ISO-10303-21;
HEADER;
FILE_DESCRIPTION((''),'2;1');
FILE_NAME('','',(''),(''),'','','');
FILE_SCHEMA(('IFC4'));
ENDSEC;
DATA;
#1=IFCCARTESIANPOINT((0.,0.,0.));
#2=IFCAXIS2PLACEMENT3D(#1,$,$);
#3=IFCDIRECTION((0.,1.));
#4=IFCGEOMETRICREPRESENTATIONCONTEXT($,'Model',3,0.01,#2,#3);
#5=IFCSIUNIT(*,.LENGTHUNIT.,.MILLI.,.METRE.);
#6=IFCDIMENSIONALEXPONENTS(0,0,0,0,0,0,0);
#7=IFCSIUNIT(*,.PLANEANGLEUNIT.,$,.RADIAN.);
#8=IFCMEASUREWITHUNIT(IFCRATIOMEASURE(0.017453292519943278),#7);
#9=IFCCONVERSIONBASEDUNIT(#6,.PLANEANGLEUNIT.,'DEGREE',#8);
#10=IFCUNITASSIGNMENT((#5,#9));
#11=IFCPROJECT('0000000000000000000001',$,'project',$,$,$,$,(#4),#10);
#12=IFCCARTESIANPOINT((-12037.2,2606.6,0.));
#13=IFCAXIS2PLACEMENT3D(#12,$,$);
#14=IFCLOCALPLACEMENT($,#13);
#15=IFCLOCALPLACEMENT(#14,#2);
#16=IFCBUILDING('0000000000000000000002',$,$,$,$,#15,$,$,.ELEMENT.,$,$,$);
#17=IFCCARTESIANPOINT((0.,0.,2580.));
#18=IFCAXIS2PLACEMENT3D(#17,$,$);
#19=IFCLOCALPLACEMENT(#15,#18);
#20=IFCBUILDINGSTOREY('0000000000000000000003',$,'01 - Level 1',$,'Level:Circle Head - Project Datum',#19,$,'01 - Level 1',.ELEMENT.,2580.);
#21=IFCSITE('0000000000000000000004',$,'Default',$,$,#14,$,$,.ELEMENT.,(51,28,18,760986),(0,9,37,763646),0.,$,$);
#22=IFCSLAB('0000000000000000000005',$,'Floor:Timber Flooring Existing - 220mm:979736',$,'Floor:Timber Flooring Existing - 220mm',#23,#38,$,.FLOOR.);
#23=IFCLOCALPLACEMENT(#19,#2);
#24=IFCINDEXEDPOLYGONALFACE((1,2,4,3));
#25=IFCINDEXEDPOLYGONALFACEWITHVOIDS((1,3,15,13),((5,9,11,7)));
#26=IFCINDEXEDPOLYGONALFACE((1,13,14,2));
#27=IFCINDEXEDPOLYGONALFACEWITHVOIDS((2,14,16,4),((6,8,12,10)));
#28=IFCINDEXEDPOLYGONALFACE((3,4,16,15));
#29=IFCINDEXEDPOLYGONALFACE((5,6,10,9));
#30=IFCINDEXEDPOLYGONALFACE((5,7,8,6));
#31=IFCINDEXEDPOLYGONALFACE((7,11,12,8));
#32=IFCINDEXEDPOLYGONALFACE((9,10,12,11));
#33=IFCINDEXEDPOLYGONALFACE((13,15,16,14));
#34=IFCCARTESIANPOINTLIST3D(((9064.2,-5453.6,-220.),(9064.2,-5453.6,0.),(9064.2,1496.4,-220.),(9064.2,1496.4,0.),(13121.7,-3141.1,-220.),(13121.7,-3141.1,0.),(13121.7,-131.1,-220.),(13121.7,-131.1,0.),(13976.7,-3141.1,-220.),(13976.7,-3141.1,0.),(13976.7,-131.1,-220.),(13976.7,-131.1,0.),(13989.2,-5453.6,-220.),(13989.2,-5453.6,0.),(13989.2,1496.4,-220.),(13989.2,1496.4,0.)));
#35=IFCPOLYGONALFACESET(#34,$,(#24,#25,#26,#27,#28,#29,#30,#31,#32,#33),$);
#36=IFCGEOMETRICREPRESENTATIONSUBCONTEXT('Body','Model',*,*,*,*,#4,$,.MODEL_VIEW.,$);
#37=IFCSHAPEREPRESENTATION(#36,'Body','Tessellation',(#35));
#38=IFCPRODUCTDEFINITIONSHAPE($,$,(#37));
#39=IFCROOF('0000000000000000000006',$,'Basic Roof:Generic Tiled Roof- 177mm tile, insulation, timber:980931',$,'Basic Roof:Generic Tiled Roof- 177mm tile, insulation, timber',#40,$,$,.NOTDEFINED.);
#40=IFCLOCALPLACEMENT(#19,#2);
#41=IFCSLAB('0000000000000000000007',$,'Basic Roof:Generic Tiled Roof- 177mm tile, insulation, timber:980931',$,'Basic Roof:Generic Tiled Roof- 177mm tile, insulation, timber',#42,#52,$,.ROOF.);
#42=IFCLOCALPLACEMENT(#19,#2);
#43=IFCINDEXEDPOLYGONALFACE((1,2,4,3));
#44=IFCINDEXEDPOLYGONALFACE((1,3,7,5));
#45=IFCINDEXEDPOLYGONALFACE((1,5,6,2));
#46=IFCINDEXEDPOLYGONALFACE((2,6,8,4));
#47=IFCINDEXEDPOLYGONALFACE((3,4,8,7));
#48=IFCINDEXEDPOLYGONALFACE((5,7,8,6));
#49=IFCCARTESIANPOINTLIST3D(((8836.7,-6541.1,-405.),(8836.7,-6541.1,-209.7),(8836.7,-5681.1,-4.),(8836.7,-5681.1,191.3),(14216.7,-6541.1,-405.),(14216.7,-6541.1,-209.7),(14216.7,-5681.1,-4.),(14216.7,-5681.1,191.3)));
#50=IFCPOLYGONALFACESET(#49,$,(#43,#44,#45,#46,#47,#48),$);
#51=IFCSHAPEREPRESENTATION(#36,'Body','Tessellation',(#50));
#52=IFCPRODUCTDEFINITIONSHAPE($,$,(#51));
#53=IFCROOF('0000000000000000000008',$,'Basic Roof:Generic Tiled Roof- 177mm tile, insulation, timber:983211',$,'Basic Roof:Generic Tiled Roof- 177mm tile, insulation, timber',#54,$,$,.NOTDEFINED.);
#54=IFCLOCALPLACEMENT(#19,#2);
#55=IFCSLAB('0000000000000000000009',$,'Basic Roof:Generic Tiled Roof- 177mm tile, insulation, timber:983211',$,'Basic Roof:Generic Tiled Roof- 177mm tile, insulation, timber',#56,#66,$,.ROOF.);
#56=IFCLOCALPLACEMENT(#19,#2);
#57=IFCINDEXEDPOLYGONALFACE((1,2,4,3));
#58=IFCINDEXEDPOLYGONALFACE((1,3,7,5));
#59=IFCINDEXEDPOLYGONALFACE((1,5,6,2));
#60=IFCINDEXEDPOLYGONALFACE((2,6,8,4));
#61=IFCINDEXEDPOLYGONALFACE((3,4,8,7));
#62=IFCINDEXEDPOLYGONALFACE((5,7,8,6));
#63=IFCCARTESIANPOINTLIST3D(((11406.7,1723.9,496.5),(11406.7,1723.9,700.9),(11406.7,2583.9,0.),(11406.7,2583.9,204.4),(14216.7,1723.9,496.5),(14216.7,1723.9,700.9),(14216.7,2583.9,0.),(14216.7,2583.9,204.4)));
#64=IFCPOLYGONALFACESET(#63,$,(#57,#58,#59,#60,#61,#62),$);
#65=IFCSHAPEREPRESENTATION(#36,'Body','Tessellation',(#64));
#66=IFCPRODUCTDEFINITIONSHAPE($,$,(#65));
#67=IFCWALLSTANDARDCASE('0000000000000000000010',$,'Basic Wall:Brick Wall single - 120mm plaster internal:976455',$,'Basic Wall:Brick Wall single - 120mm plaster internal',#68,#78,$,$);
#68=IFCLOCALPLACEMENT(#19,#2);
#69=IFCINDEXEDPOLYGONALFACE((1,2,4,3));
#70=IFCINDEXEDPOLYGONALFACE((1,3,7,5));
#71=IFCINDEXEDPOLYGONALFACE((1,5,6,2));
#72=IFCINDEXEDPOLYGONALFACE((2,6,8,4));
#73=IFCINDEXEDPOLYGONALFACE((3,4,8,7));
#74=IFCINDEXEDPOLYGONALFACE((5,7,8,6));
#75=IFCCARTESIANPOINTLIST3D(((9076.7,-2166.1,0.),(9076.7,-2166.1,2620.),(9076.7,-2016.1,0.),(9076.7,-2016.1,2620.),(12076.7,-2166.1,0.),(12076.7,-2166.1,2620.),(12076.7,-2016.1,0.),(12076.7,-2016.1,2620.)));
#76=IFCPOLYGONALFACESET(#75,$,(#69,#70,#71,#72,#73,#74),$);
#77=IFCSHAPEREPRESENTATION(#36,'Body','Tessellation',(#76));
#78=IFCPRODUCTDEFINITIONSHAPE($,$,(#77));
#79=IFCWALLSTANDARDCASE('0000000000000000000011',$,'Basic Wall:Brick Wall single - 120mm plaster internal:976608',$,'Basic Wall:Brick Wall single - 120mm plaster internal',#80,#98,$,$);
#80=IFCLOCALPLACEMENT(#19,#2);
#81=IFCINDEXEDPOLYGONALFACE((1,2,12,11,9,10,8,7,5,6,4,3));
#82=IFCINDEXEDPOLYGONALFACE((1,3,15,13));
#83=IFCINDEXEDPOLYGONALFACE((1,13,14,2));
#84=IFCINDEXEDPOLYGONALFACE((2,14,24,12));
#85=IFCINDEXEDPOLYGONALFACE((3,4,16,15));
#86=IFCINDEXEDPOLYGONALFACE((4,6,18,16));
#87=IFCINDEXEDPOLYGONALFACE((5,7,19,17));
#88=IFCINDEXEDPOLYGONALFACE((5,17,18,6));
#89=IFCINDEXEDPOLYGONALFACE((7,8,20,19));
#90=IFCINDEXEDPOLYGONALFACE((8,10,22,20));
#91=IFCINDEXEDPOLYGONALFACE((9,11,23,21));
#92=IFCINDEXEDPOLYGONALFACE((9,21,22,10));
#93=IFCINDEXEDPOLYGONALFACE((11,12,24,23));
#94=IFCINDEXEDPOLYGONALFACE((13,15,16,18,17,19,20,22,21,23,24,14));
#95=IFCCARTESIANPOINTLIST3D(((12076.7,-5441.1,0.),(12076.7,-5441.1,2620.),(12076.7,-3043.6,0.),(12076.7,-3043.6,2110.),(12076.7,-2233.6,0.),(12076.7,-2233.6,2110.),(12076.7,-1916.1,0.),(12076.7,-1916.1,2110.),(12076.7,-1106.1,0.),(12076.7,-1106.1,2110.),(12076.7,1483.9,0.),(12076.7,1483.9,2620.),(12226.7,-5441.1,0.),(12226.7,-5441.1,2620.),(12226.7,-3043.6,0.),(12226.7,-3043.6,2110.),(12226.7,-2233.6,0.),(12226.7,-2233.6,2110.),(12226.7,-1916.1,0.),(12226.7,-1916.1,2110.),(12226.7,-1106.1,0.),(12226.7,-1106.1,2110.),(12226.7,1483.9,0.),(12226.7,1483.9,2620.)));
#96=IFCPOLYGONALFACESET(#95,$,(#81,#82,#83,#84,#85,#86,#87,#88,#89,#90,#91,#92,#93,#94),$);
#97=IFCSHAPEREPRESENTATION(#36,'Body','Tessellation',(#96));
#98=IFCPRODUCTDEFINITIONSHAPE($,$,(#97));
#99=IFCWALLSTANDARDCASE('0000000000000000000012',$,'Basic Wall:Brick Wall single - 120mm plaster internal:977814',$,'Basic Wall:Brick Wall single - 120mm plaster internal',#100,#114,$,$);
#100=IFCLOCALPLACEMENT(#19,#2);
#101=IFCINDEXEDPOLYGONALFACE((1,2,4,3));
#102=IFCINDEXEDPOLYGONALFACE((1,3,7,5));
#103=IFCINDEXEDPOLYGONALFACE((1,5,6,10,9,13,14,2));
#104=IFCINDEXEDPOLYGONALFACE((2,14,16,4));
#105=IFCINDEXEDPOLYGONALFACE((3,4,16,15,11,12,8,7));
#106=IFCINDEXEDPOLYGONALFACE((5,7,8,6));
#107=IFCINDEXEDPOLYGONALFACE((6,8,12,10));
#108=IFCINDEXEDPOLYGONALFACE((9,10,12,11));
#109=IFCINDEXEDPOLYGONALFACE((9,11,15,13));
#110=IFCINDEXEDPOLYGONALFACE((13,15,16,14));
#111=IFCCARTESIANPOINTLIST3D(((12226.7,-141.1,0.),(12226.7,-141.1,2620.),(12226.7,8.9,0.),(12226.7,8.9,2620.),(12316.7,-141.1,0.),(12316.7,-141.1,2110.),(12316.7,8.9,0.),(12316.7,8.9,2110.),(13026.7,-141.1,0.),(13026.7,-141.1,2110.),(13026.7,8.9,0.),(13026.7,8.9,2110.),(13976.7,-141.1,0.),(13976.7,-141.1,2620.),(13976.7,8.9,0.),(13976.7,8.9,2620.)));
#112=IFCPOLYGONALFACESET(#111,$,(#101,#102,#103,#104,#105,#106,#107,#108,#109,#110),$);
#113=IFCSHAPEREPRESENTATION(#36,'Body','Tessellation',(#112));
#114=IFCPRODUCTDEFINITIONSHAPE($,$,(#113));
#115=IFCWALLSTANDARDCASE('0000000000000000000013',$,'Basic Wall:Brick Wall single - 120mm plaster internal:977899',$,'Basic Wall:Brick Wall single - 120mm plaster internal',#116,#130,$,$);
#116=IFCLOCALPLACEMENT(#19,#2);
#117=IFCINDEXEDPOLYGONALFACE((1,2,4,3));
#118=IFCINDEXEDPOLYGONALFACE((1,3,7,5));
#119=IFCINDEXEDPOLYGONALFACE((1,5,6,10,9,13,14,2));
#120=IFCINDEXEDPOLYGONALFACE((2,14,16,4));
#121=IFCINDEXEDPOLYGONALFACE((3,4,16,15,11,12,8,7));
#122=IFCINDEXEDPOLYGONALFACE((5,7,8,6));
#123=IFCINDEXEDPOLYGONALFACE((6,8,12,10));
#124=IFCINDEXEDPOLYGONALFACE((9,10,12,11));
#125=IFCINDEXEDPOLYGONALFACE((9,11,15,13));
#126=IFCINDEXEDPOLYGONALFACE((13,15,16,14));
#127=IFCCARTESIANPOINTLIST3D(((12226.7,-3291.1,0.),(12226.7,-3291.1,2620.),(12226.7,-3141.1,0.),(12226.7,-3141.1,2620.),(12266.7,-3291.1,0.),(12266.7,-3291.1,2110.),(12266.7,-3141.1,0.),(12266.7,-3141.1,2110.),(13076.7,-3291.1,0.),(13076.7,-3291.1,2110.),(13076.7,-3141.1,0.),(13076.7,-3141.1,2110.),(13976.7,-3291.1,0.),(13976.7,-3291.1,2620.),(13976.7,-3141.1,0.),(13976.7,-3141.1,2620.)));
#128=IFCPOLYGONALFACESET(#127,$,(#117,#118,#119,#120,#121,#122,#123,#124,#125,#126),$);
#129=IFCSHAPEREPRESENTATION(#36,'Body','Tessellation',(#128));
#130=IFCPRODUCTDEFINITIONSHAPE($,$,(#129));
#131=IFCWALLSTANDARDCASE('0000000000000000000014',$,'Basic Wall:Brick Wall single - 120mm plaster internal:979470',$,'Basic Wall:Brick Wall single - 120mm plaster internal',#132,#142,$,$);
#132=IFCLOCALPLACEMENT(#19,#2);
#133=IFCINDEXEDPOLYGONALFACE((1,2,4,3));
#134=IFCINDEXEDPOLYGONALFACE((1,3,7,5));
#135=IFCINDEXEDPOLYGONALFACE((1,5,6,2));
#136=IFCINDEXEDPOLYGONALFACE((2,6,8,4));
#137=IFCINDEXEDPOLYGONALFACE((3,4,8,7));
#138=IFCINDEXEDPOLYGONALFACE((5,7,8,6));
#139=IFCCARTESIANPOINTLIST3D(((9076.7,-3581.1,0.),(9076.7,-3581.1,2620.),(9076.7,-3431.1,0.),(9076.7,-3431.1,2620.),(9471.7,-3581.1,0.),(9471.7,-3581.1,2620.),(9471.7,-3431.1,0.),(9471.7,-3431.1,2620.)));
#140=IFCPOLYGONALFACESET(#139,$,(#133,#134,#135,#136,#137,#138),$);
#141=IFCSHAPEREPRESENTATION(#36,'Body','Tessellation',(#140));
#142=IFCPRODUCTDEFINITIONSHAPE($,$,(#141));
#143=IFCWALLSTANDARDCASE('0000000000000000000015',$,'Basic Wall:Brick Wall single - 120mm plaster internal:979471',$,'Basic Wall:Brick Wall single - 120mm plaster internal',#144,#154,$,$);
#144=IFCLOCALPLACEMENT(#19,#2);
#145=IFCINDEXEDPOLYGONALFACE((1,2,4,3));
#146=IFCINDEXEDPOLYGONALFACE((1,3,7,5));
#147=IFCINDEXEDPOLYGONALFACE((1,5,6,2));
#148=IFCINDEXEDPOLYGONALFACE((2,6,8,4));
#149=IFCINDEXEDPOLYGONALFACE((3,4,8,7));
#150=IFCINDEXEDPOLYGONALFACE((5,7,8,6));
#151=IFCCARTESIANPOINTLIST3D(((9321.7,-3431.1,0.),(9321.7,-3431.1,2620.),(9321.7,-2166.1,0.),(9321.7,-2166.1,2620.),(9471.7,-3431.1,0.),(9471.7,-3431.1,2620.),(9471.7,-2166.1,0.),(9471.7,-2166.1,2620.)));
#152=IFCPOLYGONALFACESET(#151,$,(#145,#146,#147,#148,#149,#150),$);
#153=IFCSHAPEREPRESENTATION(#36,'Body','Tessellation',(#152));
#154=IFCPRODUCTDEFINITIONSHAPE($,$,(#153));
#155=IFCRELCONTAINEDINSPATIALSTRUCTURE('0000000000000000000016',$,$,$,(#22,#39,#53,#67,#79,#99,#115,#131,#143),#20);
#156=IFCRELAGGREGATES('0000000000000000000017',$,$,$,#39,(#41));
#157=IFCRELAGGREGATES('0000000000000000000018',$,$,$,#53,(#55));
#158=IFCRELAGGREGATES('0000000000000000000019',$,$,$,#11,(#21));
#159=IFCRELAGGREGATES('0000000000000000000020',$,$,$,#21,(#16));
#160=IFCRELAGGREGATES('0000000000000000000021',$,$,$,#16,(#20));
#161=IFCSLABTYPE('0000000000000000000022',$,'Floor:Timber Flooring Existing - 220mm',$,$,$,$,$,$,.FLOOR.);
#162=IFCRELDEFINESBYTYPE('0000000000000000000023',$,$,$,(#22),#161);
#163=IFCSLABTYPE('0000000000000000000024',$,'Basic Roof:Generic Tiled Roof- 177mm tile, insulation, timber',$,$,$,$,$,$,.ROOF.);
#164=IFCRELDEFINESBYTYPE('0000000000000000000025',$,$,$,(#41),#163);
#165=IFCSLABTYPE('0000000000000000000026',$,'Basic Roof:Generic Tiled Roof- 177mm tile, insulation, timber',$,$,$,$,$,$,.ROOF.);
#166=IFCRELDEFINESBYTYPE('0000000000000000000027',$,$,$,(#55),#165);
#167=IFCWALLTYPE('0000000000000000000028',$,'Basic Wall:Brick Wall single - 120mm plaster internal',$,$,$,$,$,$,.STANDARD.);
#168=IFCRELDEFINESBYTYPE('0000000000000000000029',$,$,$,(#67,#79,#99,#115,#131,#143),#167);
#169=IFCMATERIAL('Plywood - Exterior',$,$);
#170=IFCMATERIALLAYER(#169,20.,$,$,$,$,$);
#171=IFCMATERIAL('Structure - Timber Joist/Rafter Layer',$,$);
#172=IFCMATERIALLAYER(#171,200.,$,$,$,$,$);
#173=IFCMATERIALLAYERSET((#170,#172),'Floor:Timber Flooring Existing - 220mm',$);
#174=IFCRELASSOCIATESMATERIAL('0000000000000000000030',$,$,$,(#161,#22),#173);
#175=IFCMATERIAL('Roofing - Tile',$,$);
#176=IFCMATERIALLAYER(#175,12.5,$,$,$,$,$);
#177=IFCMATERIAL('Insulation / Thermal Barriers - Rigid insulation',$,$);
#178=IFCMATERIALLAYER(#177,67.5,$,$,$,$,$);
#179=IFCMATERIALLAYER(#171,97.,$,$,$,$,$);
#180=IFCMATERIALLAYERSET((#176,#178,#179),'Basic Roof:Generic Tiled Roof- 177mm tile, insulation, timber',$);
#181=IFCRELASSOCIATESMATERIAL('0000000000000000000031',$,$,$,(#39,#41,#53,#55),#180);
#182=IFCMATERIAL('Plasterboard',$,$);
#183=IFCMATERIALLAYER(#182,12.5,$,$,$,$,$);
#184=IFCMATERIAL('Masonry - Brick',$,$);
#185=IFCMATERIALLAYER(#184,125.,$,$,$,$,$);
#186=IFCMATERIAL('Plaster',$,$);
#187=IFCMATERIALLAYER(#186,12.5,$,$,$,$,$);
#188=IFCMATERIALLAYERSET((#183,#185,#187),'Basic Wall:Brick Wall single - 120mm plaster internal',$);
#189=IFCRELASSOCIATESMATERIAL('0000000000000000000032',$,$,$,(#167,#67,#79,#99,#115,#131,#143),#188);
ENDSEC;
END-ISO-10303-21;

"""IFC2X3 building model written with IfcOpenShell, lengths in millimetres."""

from ifc_helpers import new_model, entity, si_unit, converted_unit, direction, frame, frame_2d, origin, place, context, subcontext, project, spatial, rectangle, extrude, material, layer, layer_set, layer_usage, type_object, element, aggregate, save


model = new_model("IFC2X3")

# Units and contexts
model_context = context("Model", 3, precision=0.01, world=origin(), true_north=direction((0.0, 1.0)))
body_context = subcontext(model_context, "Body", "Model", "MODEL_VIEW")
ifc_project = project(units=[si_unit("LENGTHUNIT", "METRE", prefix="MILLI"), converted_unit("PLANEANGLEUNIT", "DEGREE", entity("IfcRatioMeasure", 0.017453292519943278), si_unit("PLANEANGLEUNIT", "RADIAN"), dimensions=[0, 0, 0, 0, 0, 0, 0])], contexts=[model_context])

# Site, building, storey
site_placement = place(None, frame((-12037.2, 2606.6, 0.0)))
site = spatial("IfcSite", under=ifc_project, at=site_placement, Name="Default", CompositionType="ELEMENT", RefLatitude=(51, 28, 18, 760986), RefLongitude=(0, 9, 37, 763646), RefElevation=0.0)
building_placement = place(site_placement, origin())
building = spatial("IfcBuilding", under=site, at=building_placement, CompositionType="ELEMENT")
storey_placement = place(building_placement, frame((0.0, 0.0, 2580.0)))
storey = spatial("IfcBuildingStorey", under=building, at=storey_placement, Name="01 - Level 1", ObjectType="Level:Circle Head - Project Datum", LongName="01 - Level 1", CompositionType="ELEMENT", Elevation=2580.0)

# Slab, opening
ifc_material_1 = material(Name="Plywood - Exterior")
ifc_layer_1 = layer(ifc_material_1, 20.0)
ifc_material_2 = material(Name="Structure - Timber Joist/Rafter Layer")
ifc_layer_2 = layer(ifc_material_2, 200.0)
ifc_layer_set_1 = layer_set([ifc_layer_1, ifc_layer_2], Name="Floor:Timber Flooring Existing - 220mm")
ifc_layer_usage_1 = layer_usage(ifc_layer_set_1, "AXIS3", "POSITIVE", 0.0)
slab_type_1 = type_object("IfcSlabType", Name="Floor:Timber Flooring Existing - 220mm", PredefinedType="FLOOR", material=ifc_layer_set_1)
slab_1_placement = place(storey_placement, frame((9064.2, -5453.6, -220.0)))
slab_1 = element("IfcSlab", 1, at=slab_1_placement, inside=storey, type_object=slab_type_1, material=ifc_layer_usage_1, Name="Floor:Timber Flooring Existing - 220mm:979736", ObjectType="Floor:Timber Flooring Existing - 220mm", PredefinedType="FLOOR", context=body_context, shape_type="SweptSolid", body=[
    extrude(rectangle(XDim=4925.0, YDim=6950.0, at=frame_2d((0.0, 0.0), x_axis=(-1.0, 0.0))), frame((2462.5, 3475.0, 220.0), z_axis=(0.0, 0.0, -1.0), x_axis=(-1.0, 0.0, 0.0)), (0.0, 0.0, 1.0), 220.0),
])
opening_1_placement = place(storey_placement, frame((9064.2, -5453.6, -220.0)))
element("IfcOpeningElement", 2, at=opening_1_placement, cuts=slab_1, ObjectType="Opening", context=body_context, shape_type="SweptSolid", body=[
    extrude(rectangle(XDim=3010.0, YDim=855.0, at=frame_2d((-2022.5, 342.5), x_axis=(0.0, -1.0))), frame((2462.5, 3475.0, 220.0), z_axis=(0.0, 0.0, -1.0), x_axis=(-1.0, 0.0, 0.0)), (0.0, 0.0, 1.0), 220.0),
])

# Roofs, slabs
ifc_material_3 = material(Name="Roofing - Tile")
ifc_layer_3 = layer(ifc_material_3, 12.5)
ifc_material_4 = material(Name="Insulation / Thermal Barriers - Rigid insulation")
ifc_layer_4 = layer(ifc_material_4, 67.5)
ifc_layer_5 = layer(ifc_material_2, 97.0)
ifc_layer_set_2 = layer_set([ifc_layer_3, ifc_layer_4, ifc_layer_5], Name="Basic Roof:Generic Tiled Roof- 177mm tile, insulation, timber")
roof_1_placement = place(storey_placement, frame((8836.7, -6541.1, -405.0)))
roof_1 = element("IfcRoof", 3, at=roof_1_placement, inside=storey, material=ifc_layer_set_2, Name="Basic Roof:Generic Tiled Roof- 177mm tile, insulation, timber:980931", ObjectType="Basic Roof:Generic Tiled Roof- 177mm tile, insulation, timber", ShapeType="NOTDEFINED")
slab_type_2 = type_object("IfcSlabType", Name="Basic Roof:Generic Tiled Roof- 177mm tile, insulation, timber", PredefinedType="ROOF")
slab_2_placement = place(roof_1_placement, origin())
slab_2 = element("IfcSlab", 4, at=slab_2_placement, type_object=slab_type_2, material=ifc_layer_set_2, Name="Basic Roof:Generic Tiled Roof- 177mm tile, insulation, timber:980931", ObjectType="Basic Roof:Generic Tiled Roof- 177mm tile, insulation, timber", PredefinedType="ROOF", context=body_context, shape_type="SweptSolid", body=[
    extrude(rectangle(XDim=948.9, YDim=5380.0, at=frame_2d((0.0, 0.0), x_axis=(0.0, -1.0))), frame((2690.0, 430.0, 200.5), z_axis=(0.0, -0.422618, 0.906308), x_axis=(1.0, 0.0, 0.0)), (0.0, 0.422618, 0.906308), 195.3),
])
aggregate(roof_1, [slab_2])
roof_2_placement = place(storey_placement, frame((11406.7, 1723.9, 0.0)))
roof_2 = element("IfcRoof", 5, at=roof_2_placement, inside=storey, material=ifc_layer_set_2, Name="Basic Roof:Generic Tiled Roof- 177mm tile, insulation, timber:983211", ObjectType="Basic Roof:Generic Tiled Roof- 177mm tile, insulation, timber", ShapeType="NOTDEFINED")
slab_type_3 = type_object("IfcSlabType", Name="Basic Roof:Generic Tiled Roof- 177mm tile, insulation, timber", PredefinedType="ROOF")
slab_3_placement = place(roof_2_placement, origin())
slab_3 = element("IfcSlab", 6, at=slab_3_placement, type_object=slab_type_3, material=ifc_layer_set_2, Name="Basic Roof:Generic Tiled Roof- 177mm tile, insulation, timber:983211", ObjectType="Basic Roof:Generic Tiled Roof- 177mm tile, insulation, timber", PredefinedType="ROOF", context=body_context, shape_type="SweptSolid", body=[
    extrude(rectangle(XDim=993.0, YDim=2810.0, at=frame_2d((0.0, 0.0), x_axis=(0.0, 1.0))), frame((1405.0, 430.0, 248.3), z_axis=(0.0, 0.5, 0.866025), x_axis=(1.0, 0.0, 0.0)), (0.0, -0.5, 0.866025), 204.4),
])
aggregate(roof_2, [slab_3])

# Wall
ifc_material_5 = material(Name="Plasterboard")
ifc_layer_6 = layer(ifc_material_5, 12.5)
ifc_material_6 = material(Name="Masonry - Brick")
ifc_layer_7 = layer(ifc_material_6, 125.0)
ifc_material_7 = material(Name="Plaster")
ifc_layer_8 = layer(ifc_material_7, 12.5)
ifc_layer_set_3 = layer_set([ifc_layer_6, ifc_layer_7, ifc_layer_8], Name="Basic Wall:Brick Wall single - 120mm plaster internal")
ifc_layer_usage_2 = layer_usage(ifc_layer_set_3, "AXIS2", "NEGATIVE", 75.0)
wall_type_1 = type_object("IfcWallType", Name="Basic Wall:Brick Wall single - 120mm plaster internal", PredefinedType="STANDARD", material=ifc_layer_set_3)
wall_1_placement = place(storey_placement, frame((9076.7, -2091.1, 0.0)))
element("IfcWallStandardCase", 7, at=wall_1_placement, inside=storey, type_object=wall_type_1, material=ifc_layer_usage_2, Name="Basic Wall:Brick Wall single - 120mm plaster internal:976455", ObjectType="Basic Wall:Brick Wall single - 120mm plaster internal", context=body_context, shape_type="SweptSolid", body=[
    extrude(rectangle(XDim=3000.0, YDim=150.0, at=frame_2d((1500.0, 0.0), x_axis=(-1.0, 0.0))), origin(), (0.0, 0.0, 1.0), 2620.0),
])

# Wall, openings
ifc_layer_usage_3 = layer_usage(ifc_layer_set_3, "AXIS2", "NEGATIVE", 75.0)
wall_2_placement = place(storey_placement, frame((12151.7, 1483.9, 0.0), z_axis=(0.0, 0.0, 1.0), x_axis=(0.0, -1.0, 0.0)))
wall_2 = element("IfcWallStandardCase", 8, at=wall_2_placement, inside=storey, type_object=wall_type_1, material=ifc_layer_usage_3, Name="Basic Wall:Brick Wall single - 120mm plaster internal:976608", ObjectType="Basic Wall:Brick Wall single - 120mm plaster internal", context=body_context, shape_type="SweptSolid", body=[
    extrude(rectangle(XDim=6925.0, YDim=150.0, at=frame_2d((3462.5, 0.0), x_axis=(1.0, 0.0))), origin(), (0.0, 0.0, 1.0), 2620.0),
])
opening_2_placement = place(wall_2_placement, frame((3400.0, 75.0, 0.0)))
element("IfcOpeningElement", 9, at=opening_2_placement, cuts=wall_2, ObjectType="Opening", context=body_context, shape_type="SweptSolid", body=[
    extrude(rectangle(XDim=2110.0, YDim=810.0, at=frame_2d((1055.0, 405.0), x_axis=(1.0, 0.0))), frame((0.0, 0.0, 0.0), z_axis=(0.0, -1.0, 0.0), x_axis=(0.0, 0.0, 1.0)), (0.0, 0.0, 1.0), 150.0),
])
opening_3_placement = place(wall_2_placement, frame((4527.5, 75.0, 0.0)))
element("IfcOpeningElement", 10, at=opening_3_placement, cuts=wall_2, ObjectType="Opening", context=body_context, shape_type="SweptSolid", body=[
    extrude(rectangle(XDim=2110.0, YDim=810.0, at=frame_2d((1055.0, 405.0), x_axis=(1.0, 0.0))), frame((0.0, 0.0, 0.0), z_axis=(0.0, -1.0, 0.0), x_axis=(0.0, 0.0, 1.0)), (0.0, 0.0, 1.0), 150.0),
])

# Walls, openings
ifc_layer_usage_4 = layer_usage(ifc_layer_set_3, "AXIS2", "NEGATIVE", 75.0)
wall_3_placement = place(storey_placement, frame((13976.7, -66.1, 0.0), z_axis=(0.0, 0.0, 1.0), x_axis=(-1.0, 0.0, 0.0)))
wall_3 = element("IfcWallStandardCase", 11, at=wall_3_placement, inside=storey, type_object=wall_type_1, material=ifc_layer_usage_4, Name="Basic Wall:Brick Wall single - 120mm plaster internal:977814", ObjectType="Basic Wall:Brick Wall single - 120mm plaster internal", context=body_context, shape_type="SweptSolid", body=[
    extrude(rectangle(XDim=1750.0, YDim=150.0, at=frame_2d((875.0, 0.0), x_axis=(1.0, 0.0))), origin(), (0.0, 0.0, 1.0), 2620.0),
])
opening_4_placement = place(wall_3_placement, frame((1660.0, 75.0, 0.0)))
element("IfcOpeningElement", 12, at=opening_4_placement, cuts=wall_3, ObjectType="Opening", context=body_context, shape_type="SweptSolid", body=[
    extrude(rectangle(XDim=2110.0, YDim=710.0, at=frame_2d((1055.0, 355.0), x_axis=(1.0, 0.0))), frame((0.0, 0.0, 0.0), z_axis=(0.0, -1.0, 0.0), x_axis=(0.0, 0.0, 1.0)), (0.0, 0.0, 1.0), 150.0),
])
ifc_layer_usage_5 = layer_usage(ifc_layer_set_3, "AXIS2", "NEGATIVE", 75.0)
wall_4_placement = place(storey_placement, frame((13976.7, -3216.1, 0.0), z_axis=(0.0, 0.0, 1.0), x_axis=(-1.0, 0.0, 0.0)))
wall_4 = element("IfcWallStandardCase", 13, at=wall_4_placement, inside=storey, type_object=wall_type_1, material=ifc_layer_usage_5, Name="Basic Wall:Brick Wall single - 120mm plaster internal:977899", ObjectType="Basic Wall:Brick Wall single - 120mm plaster internal", context=body_context, shape_type="SweptSolid", body=[
    extrude(rectangle(XDim=1750.0, YDim=150.0, at=frame_2d((875.0, 0.0), x_axis=(1.0, 0.0))), origin(), (0.0, 0.0, 1.0), 2620.0),
])
opening_5_placement = place(wall_4_placement, frame((1710.0, 75.0, 0.0)))
element("IfcOpeningElement", 14, at=opening_5_placement, cuts=wall_4, ObjectType="Opening", context=body_context, shape_type="SweptSolid", body=[
    extrude(rectangle(XDim=2110.0, YDim=810.0, at=frame_2d((1055.0, 405.0), x_axis=(1.0, 0.0))), frame((0.0, 0.0, 0.0), z_axis=(0.0, -1.0, 0.0), x_axis=(0.0, 0.0, 1.0)), (0.0, 0.0, 1.0), 150.0),
])

# Walls
ifc_layer_usage_6 = layer_usage(ifc_layer_set_3, "AXIS2", "NEGATIVE", 75.0)
wall_5_placement = place(storey_placement, frame((9076.7, -3506.1, 0.0)))
element("IfcWallStandardCase", 15, at=wall_5_placement, inside=storey, type_object=wall_type_1, material=ifc_layer_usage_6, Name="Basic Wall:Brick Wall single - 120mm plaster internal:979470", ObjectType="Basic Wall:Brick Wall single - 120mm plaster internal", context=body_context, shape_type="SweptSolid", body=[
    extrude(rectangle(XDim=395.0, YDim=150.0, at=frame_2d((197.5, 0.0), x_axis=(-1.0, 0.0))), origin(), (0.0, 0.0, 1.0), 2620.0),
])
ifc_layer_usage_7 = layer_usage(ifc_layer_set_3, "AXIS2", "NEGATIVE", 75.0)
wall_6_placement = place(storey_placement, frame((9396.7, -3431.1, 0.0), z_axis=(0.0, 0.0, 1.0), x_axis=(0.0, 1.0, 0.0)))
element("IfcWallStandardCase", 16, at=wall_6_placement, inside=storey, type_object=wall_type_1, material=ifc_layer_usage_7, Name="Basic Wall:Brick Wall single - 120mm plaster internal:979471", ObjectType="Basic Wall:Brick Wall single - 120mm plaster internal", context=body_context, shape_type="SweptSolid", body=[
    extrude(rectangle(XDim=1265.0, YDim=150.0, at=frame_2d((632.5, 0.0), x_axis=(-1.0, 0.0))), origin(), (0.0, 0.0, 1.0), 2620.0),
])

save(model, "model.ifc")
